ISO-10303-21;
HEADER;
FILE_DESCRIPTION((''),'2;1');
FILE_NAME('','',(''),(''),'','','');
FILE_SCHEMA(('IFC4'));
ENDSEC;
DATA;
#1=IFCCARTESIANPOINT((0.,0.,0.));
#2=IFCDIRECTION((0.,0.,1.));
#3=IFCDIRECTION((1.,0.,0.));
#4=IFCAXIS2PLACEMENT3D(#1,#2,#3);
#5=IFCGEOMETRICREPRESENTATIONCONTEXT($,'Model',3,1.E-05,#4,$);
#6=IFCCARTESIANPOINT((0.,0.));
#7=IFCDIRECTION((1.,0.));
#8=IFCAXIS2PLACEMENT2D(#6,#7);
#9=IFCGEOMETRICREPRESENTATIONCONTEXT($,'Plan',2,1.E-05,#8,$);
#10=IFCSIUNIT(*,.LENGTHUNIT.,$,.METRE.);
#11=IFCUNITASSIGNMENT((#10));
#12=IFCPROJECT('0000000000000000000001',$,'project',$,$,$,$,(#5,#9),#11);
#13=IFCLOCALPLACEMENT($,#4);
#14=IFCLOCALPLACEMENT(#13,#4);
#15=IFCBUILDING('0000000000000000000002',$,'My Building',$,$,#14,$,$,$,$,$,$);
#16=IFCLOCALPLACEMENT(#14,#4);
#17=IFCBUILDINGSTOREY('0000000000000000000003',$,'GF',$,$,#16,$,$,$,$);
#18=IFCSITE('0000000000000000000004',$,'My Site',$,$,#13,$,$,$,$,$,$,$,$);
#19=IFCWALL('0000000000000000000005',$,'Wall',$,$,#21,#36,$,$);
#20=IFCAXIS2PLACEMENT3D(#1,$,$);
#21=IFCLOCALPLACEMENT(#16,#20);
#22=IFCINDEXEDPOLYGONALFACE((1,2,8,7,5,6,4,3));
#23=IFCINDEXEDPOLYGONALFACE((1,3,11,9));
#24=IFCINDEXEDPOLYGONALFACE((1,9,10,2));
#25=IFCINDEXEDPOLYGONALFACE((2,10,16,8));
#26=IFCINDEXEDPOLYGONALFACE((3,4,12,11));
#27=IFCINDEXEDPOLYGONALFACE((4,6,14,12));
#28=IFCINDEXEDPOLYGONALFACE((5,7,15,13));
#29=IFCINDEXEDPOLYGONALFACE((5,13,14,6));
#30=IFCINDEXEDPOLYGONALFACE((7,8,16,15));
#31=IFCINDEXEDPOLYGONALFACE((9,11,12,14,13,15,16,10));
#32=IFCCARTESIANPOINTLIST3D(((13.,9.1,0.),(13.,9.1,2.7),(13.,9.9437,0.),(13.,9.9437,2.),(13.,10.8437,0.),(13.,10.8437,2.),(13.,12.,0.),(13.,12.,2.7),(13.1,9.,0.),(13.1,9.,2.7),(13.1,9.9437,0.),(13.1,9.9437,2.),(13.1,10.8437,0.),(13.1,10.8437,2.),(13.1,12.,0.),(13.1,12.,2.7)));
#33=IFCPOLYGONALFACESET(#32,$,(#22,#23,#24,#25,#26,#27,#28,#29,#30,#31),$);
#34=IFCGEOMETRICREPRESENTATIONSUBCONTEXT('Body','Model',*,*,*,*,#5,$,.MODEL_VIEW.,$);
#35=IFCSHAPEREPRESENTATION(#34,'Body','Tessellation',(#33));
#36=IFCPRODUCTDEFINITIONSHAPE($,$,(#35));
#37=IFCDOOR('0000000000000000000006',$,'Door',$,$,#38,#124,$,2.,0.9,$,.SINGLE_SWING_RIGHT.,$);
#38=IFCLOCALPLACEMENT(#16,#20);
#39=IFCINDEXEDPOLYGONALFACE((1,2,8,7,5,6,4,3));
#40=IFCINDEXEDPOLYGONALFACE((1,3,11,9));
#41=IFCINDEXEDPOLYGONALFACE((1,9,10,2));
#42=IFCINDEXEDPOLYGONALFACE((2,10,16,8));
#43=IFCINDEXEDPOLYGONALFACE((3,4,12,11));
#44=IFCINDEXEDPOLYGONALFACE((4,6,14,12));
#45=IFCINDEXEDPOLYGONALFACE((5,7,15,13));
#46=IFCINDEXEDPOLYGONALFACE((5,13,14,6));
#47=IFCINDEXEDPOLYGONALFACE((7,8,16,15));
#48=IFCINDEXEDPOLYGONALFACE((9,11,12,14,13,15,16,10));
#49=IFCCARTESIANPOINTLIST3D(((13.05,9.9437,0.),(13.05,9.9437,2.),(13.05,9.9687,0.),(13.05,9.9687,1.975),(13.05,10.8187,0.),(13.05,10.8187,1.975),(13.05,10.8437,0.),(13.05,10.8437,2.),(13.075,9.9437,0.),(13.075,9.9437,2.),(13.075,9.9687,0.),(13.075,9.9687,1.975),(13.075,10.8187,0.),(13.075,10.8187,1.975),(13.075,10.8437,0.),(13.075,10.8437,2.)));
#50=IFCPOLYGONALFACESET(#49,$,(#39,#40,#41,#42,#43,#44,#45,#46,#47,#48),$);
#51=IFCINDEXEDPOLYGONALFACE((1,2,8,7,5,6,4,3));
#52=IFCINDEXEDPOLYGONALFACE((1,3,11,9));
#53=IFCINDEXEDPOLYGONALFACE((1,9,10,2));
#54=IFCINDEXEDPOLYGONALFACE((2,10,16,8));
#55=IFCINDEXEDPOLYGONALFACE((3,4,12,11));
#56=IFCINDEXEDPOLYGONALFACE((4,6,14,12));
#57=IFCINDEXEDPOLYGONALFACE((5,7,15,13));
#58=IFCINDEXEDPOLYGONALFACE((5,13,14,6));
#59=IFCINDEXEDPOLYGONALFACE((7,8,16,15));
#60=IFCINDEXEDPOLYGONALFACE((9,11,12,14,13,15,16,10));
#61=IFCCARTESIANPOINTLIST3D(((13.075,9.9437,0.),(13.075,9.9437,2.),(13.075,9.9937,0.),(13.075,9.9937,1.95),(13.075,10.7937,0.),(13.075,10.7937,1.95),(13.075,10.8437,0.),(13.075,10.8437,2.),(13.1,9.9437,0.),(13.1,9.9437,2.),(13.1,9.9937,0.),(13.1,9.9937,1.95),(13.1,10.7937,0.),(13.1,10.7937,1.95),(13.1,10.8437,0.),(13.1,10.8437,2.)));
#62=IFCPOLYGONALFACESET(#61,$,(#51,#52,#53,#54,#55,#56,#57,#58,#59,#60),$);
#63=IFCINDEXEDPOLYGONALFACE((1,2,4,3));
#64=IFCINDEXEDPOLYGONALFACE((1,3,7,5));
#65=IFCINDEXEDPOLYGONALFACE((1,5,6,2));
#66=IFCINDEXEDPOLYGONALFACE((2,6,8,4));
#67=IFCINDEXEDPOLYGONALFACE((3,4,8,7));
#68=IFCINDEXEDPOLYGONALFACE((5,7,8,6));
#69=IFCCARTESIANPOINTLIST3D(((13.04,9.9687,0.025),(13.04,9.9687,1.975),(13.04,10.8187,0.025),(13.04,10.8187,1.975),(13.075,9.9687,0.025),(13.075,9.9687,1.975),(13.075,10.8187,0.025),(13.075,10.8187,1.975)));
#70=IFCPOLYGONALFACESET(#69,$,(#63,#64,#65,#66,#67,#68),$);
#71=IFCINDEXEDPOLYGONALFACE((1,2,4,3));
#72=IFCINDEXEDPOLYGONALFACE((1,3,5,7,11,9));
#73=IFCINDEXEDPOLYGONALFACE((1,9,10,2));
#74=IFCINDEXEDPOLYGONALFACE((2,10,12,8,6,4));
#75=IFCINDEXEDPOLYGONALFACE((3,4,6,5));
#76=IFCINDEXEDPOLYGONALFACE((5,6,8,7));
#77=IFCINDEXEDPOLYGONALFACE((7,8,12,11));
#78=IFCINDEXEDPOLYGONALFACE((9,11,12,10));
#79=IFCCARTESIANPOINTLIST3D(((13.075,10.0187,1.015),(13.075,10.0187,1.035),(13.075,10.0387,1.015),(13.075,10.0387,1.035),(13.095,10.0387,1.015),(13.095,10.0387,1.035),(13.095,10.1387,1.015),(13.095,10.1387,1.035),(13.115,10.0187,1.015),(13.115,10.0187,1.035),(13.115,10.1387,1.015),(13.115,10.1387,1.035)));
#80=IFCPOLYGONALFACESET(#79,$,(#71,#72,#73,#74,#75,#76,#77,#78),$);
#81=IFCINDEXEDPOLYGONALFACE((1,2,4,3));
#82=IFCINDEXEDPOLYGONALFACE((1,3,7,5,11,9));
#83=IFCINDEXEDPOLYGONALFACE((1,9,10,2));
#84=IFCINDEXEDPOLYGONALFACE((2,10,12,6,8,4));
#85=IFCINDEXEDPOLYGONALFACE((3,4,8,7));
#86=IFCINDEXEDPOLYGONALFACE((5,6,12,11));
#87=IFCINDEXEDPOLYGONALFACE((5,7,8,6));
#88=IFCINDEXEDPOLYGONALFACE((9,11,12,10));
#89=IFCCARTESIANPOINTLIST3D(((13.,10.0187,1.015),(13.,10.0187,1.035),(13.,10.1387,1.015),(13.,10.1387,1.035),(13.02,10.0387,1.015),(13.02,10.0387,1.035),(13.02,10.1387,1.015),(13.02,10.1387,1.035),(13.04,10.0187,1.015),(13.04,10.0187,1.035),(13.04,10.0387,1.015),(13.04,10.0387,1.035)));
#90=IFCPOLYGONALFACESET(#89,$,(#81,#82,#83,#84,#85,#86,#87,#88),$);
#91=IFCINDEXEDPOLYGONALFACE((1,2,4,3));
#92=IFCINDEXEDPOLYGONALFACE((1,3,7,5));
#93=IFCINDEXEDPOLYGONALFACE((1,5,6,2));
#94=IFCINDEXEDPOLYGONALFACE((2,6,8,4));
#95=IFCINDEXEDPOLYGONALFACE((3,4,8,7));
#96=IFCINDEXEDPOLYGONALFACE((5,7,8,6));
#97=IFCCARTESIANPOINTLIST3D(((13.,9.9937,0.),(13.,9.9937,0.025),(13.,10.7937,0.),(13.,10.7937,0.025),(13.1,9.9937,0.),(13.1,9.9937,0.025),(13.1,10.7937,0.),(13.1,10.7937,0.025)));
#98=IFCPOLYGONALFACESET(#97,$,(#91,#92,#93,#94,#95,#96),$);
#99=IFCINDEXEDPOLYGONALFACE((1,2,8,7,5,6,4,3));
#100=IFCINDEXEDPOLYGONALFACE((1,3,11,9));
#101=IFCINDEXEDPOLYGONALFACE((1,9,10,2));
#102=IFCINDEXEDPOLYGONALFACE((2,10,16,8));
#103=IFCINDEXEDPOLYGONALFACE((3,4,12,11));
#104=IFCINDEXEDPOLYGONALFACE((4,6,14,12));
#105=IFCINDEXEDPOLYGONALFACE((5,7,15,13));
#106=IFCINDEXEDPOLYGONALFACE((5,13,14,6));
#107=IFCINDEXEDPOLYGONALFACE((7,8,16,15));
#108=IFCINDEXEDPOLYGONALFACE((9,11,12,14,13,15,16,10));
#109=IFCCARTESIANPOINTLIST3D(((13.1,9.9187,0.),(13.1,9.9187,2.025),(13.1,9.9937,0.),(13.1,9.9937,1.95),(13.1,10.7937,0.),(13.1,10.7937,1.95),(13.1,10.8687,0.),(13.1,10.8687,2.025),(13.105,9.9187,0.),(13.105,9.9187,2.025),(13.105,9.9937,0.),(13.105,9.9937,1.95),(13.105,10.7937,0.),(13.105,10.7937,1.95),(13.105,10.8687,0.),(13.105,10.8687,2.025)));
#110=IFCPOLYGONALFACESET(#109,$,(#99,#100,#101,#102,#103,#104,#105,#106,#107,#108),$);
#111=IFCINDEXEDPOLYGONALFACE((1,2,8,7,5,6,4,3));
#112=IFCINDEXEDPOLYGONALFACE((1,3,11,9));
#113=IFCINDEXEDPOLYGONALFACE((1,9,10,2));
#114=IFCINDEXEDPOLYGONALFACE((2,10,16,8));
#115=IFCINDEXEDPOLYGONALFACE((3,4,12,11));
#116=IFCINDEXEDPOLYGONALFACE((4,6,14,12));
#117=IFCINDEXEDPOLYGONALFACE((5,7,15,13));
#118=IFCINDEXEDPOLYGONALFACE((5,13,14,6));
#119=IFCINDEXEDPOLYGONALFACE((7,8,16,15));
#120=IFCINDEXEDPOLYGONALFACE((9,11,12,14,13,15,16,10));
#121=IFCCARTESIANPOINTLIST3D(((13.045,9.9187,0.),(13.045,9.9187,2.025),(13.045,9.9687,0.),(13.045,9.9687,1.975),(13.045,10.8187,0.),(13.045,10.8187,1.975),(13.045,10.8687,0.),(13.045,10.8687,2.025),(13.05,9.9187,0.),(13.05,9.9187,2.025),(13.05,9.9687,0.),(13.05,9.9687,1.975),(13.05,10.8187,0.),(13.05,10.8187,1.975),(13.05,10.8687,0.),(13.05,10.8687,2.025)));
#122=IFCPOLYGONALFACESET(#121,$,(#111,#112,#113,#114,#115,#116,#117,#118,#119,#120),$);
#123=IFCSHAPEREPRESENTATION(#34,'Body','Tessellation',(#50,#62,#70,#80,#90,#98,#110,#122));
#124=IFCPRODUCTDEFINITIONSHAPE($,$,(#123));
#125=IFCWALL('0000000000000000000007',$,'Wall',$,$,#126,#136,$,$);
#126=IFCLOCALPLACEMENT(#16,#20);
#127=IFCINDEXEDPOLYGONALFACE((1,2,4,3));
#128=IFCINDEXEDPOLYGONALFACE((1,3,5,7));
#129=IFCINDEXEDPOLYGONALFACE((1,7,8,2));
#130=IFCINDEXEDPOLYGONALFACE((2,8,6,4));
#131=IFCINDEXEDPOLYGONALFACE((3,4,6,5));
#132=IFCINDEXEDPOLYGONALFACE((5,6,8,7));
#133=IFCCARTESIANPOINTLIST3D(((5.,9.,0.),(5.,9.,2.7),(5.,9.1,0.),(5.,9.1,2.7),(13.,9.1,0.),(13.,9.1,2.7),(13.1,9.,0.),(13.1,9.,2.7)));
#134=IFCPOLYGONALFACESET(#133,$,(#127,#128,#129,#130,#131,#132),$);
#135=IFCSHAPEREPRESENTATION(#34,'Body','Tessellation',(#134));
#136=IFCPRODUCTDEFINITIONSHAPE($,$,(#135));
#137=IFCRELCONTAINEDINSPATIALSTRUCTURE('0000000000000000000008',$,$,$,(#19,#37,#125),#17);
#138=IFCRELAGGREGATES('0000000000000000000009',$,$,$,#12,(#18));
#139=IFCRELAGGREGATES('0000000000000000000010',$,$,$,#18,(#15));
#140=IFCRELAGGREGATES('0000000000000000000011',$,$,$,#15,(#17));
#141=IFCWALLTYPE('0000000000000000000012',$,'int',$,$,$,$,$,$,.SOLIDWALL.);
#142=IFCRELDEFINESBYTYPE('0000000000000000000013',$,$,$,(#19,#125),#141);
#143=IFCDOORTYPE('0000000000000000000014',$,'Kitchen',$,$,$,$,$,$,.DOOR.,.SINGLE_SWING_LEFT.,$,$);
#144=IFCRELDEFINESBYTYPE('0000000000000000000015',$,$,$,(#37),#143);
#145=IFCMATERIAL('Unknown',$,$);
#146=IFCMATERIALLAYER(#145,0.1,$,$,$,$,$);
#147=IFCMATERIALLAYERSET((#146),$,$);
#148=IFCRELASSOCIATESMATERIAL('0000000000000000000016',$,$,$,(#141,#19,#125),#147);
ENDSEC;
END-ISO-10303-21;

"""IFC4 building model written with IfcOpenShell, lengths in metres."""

from ifc_helpers import new_model, entity, si_unit, frame, origin_with_axes, origin_2d_with_axis, place, context, subcontext, project, spatial, line, indexed_curve, outline, extrude, shape, source, transform, mapped, material, layer, layer_set, layer_usage, type_object, type_shapes, element, fill, save


model = new_model("IFC4")

# Units and contexts
model_context = context("Model", 3, precision=1e-05, world=origin_with_axes())
plan_context = context("Plan", 2, precision=1e-05, world=origin_2d_with_axis())
body_context_1 = subcontext(model_context, "Body", "Model", "MODEL_VIEW")
body_context_2 = subcontext(plan_context, "Body", "Plan", "PLAN_VIEW")
ifc_project = project(units=[si_unit("LENGTHUNIT", "METRE")], contexts=[model_context, plan_context])

# Site, building, storey
site_placement = place(None, origin_with_axes())
site = spatial("IfcSite", under=ifc_project, at=site_placement, Name="My Site")
building_placement = place(site_placement, origin_with_axes())
building = spatial("IfcBuilding", under=site, at=building_placement, Name="My Building")
storey_placement = place(building_placement, origin_with_axes())
storey = spatial("IfcBuildingStorey", under=building, at=storey_placement, Name="GF")

# Shared definitions
ifc_material = material(Name="Unknown")

# Wall, opening, door
ifc_layer_1 = layer(ifc_material, 0.1)
ifc_layer_set_1 = layer_set([ifc_layer_1])
wall_type_1 = type_object("IfcWallType", Name="int", PredefinedType="SOLIDWALL", material=ifc_layer_set_1)
ifc_layer_usage_1 = layer_usage(ifc_layer_set_1, "AXIS2", "POSITIVE", 0.0)
wall_1_placement = place(storey_placement, frame((13.0, 12.0, 0.0), z_axis=(0.0, 0.0, 1.0), x_axis=(0.000001, -1.0, 0.0)))
wall_1 = element("IfcWall", 1, at=wall_1_placement, inside=storey, type_object=wall_type_1, material=ifc_layer_usage_1, Name="Wall", context=body_context_1, shape_type="SweptSolid", body=[
    extrude(outline(indexed_curve([(0.0, 0.0), (0.0, 0.1), (3.0, 0.1), (2.9, 0.0)], segments=[line(1, 2, 3, 4, 1)])), origin_with_axes(), (0.0, 0.0, 1.0), 2.7),
])
shared_shape_1 = source(origin_with_axes(), body_context_1, "Body", "SweptSolid", [
    extrude(outline(indexed_curve([(0.0, 0.0), (0.9, 0.0), (0.9, 2.0), (0.0, 2.0)], segments=[line(1, 2, 3, 4, 1)])), frame((0.0, -0.6, 0.0), z_axis=(0.0, -1.0, 0.0), x_axis=(1.0, 0.0, 0.0)), (0.0, 0.0, -1.0), 1.2),
])
opening_1_placement = place(wall_1_placement, frame((2.0563, 0.1, 0.0), z_axis=(0.0, 0.0, 1.0), x_axis=(-1.0, 0.0, 0.0)))
opening_1 = element("IfcOpeningElement", 2, at=opening_1_placement, cuts=wall_1, PredefinedType="OPENING", context=body_context_1, shape_type="MappedRepresentation", body=[
    mapped(shared_shape_1, transform((0.0, 0.0, 0.0), x_axis=(1.0, 0.0, 0.0), y_axis=(0.0, 1.0, 0.0), z_axis=(0.0, 0.0, 1.0), scale=1.0)),
])
door_type_1 = type_object("IfcDoorType", Name="Kitchen", OperationType="SINGLE_SWING_LEFT", PredefinedType="DOOR")
shared_shape_2 = source(origin_with_axes(), body_context_1, "Body", "SweptSolid", [
    extrude(outline(indexed_curve([(0.0, 0.0), (0.0, 2.0), (0.9, 2.0), (0.9, 0.0), (0.875, 0.0), (0.875, 1.975), (0.025, 1.975), (0.025, 0.0)], segments=[line(1, 2, 3, 4, 5, 6, 7, 8, 1)])), frame((0.0, 0.025, 0.0), z_axis=(0.0, -1.0, 0.0), x_axis=(1.0, 0.0, 0.0)), (0.0, 0.0, -1.0), 0.025),
    extrude(outline(indexed_curve([(0.0, 0.0), (0.0, 2.0), (0.9, 2.0), (0.9, 0.0), (0.85, 0.0), (0.85, 1.95), (0.05, 1.95), (0.05, 0.0)], segments=[line(1, 2, 3, 4, 5, 6, 7, 8, 1)])), frame((0.0, 0.0, 0.0), z_axis=(0.0, -1.0, 0.0), x_axis=(1.0, 0.0, 0.0)), (0.0, 0.0, -1.0), 0.025),
    extrude(outline(indexed_curve([(0.0, 0.0), (0.85, 0.0), (0.85, 0.035), (0.0, 0.035)], segments=[line(1, 2, 3, 4, 1)])), frame((0.025, 0.025, 0.025), z_axis=(0.0, 0.0, 1.0), x_axis=(1.0, 0.0, 0.0)), (0.0, 0.0, 1.0), 1.95),
    extrude(outline(indexed_curve([(0.0, 0.0), (0.0, -0.04), (0.12, -0.04), (0.12, -0.02), (0.02, -0.02), (0.02, 0.0)], segments=[line(1, 2, 3, 4, 5, 6, 1)])), frame((0.075, 0.025, 1.015), z_axis=(0.0, 0.0, 1.0), x_axis=(1.0, 0.0, 0.0)), (0.0, 0.0, 1.0), 0.02),
    extrude(outline(indexed_curve([(0.0, 0.0), (0.0, 0.04), (0.12, 0.04), (0.12, 0.02), (0.02, 0.02), (0.02, 0.0)], segments=[line(1, 2, 3, 4, 5, 6, 1)])), frame((0.075, 0.06, 1.015), z_axis=(0.0, 0.0, 1.0), x_axis=(1.0, 0.0, 0.0)), (0.0, 0.0, 1.0), 0.02),
    extrude(outline(indexed_curve([(0.0, 0.0), (0.8, 0.0), (0.8, 0.1), (0.0, 0.1)], segments=[line(1, 2, 3, 4, 1)])), frame((0.05, 0.0, 0.0), z_axis=(0.0, 0.0, 1.0), x_axis=(1.0, 0.0, 0.0)), (0.0, 0.0, 1.0), 0.025),
    extrude(outline(indexed_curve([(0.0, 0.0), (0.0, 2.025), (0.95, 2.025), (0.95, 0.0), (0.875, 0.0), (0.875, 1.95), (0.075, 1.95), (0.075, 0.0)], segments=[line(1, 2, 3, 4, 5, 6, 7, 8, 1)])), frame((-0.025, -0.005, 0.0), z_axis=(0.0, -1.0, 0.0), x_axis=(1.0, 0.0, 0.0)), (0.0, 0.0, -1.0), 0.005),
    extrude(outline(indexed_curve([(0.0, 0.0), (0.0, 2.025), (0.95, 2.025), (0.95, 0.0), (0.9, 0.0), (0.9, 1.975), (0.05, 1.975), (0.05, 0.0)], segments=[line(1, 2, 3, 4, 5, 6, 7, 8, 1)])), frame((-0.025, 0.05, 0.0), z_axis=(0.0, -1.0, 0.0), x_axis=(1.0, 0.0, 0.0)), (0.0, 0.0, -1.0), 0.005),
])
shared_shape_3 = source(origin_with_axes(), body_context_2, "Body", "Curve2D", [
    entity("IfcIndexedPolyCurve", entity("IfcCartesianPointList2D", [[0.0, 0.0], [0.0, 0.05], [0.025, 0.05], [0.025, 0.025], [0.05, 0.025], [0.05, 0.0]]), [entity("IfcLineIndex", [1, 2, 3, 4, 5, 6, 1])]),
    entity("IfcIndexedPolyCurve", entity("IfcCartesianPointList2D", [[0.9, 0.0], [0.9, 0.05], [0.875, 0.05], [0.875, 0.025], [0.85, 0.025], [0.85, 0.0]]), [entity("IfcLineIndex", [1, 2, 3, 4, 5, 6, 1])]),
    entity("IfcTrimmedCurve", entity("IfcEllipse", entity("IfcAxis2Placement2D", entity("IfcCartesianPoint", [0.84, 0.05]), entity("IfcDirection", [1.0, 0.0])), 0.815, 0.85), [entity("IfcCartesianPoint", [0.84, 0.9])], [entity("IfcCartesianPoint", [0.025, 0.05])], True, "CARTESIAN"),
    entity("IfcIndexedPolyCurve", entity("IfcCartesianPointList2D", [[0.875, 0.05], [0.84, 0.05], [0.84, 0.9], [0.875, 0.9]]), [entity("IfcLineIndex", [1, 2, 3, 4, 1])]),
])
type_shapes(door_type_1, [shared_shape_2, shared_shape_3])
door_1_placement = place(opening_1_placement, frame((0.0, 0.0, 0.0), z_axis=(0.0, 0.0, 1.0), x_axis=(1.0, 0.0, 0.0)))
door_1 = element("IfcDoor", 3, at=door_1_placement, inside=storey, type_object=door_type_1, Name="Door", OperationType="SINGLE_SWING_RIGHT", OverallHeight=2.0, OverallWidth=0.9, shapes=[
    shape(body_context_1, "Body", "MappedRepresentation", [mapped(shared_shape_2, transform((0.0, 0.0, 0.0), x_axis=(1.0, 0.0, 0.0), y_axis=(0.0, 1.0, 0.0), z_axis=(0.0, 0.0, 1.0), scale=1.0))]),
    shape(body_context_2, "Body", "MappedRepresentation", [mapped(shared_shape_3, transform((0.0, 0.0, 0.0), x_axis=(1.0, 0.0, 0.0), y_axis=(0.0, 1.0, 0.0), z_axis=(0.0, 0.0, 1.0), scale=1.0))]),
])
fill(opening_1, door_1)

# Wall
ifc_layer_usage_2 = layer_usage(ifc_layer_set_1, "AXIS2", "POSITIVE", 0.0)
wall_2_placement = place(storey_placement, frame((5.0, 9.0, 0.0), z_axis=(0.0, 0.0, 1.0), x_axis=(1.0, 0.0, 0.0)))
element("IfcWall", 4, at=wall_2_placement, inside=storey, type_object=wall_type_1, material=ifc_layer_usage_2, Name="Wall", context=body_context_1, shape_type="SweptSolid", body=[
    extrude(outline(indexed_curve([(0.0, 0.0), (0.0, 0.1), (8.0, 0.1), (8.1, 0.0)], segments=[line(1, 2, 3, 4, 1)])), origin_with_axes(), (0.0, 0.0, 1.0), 2.7),
])

save(model, "model.ifc")
